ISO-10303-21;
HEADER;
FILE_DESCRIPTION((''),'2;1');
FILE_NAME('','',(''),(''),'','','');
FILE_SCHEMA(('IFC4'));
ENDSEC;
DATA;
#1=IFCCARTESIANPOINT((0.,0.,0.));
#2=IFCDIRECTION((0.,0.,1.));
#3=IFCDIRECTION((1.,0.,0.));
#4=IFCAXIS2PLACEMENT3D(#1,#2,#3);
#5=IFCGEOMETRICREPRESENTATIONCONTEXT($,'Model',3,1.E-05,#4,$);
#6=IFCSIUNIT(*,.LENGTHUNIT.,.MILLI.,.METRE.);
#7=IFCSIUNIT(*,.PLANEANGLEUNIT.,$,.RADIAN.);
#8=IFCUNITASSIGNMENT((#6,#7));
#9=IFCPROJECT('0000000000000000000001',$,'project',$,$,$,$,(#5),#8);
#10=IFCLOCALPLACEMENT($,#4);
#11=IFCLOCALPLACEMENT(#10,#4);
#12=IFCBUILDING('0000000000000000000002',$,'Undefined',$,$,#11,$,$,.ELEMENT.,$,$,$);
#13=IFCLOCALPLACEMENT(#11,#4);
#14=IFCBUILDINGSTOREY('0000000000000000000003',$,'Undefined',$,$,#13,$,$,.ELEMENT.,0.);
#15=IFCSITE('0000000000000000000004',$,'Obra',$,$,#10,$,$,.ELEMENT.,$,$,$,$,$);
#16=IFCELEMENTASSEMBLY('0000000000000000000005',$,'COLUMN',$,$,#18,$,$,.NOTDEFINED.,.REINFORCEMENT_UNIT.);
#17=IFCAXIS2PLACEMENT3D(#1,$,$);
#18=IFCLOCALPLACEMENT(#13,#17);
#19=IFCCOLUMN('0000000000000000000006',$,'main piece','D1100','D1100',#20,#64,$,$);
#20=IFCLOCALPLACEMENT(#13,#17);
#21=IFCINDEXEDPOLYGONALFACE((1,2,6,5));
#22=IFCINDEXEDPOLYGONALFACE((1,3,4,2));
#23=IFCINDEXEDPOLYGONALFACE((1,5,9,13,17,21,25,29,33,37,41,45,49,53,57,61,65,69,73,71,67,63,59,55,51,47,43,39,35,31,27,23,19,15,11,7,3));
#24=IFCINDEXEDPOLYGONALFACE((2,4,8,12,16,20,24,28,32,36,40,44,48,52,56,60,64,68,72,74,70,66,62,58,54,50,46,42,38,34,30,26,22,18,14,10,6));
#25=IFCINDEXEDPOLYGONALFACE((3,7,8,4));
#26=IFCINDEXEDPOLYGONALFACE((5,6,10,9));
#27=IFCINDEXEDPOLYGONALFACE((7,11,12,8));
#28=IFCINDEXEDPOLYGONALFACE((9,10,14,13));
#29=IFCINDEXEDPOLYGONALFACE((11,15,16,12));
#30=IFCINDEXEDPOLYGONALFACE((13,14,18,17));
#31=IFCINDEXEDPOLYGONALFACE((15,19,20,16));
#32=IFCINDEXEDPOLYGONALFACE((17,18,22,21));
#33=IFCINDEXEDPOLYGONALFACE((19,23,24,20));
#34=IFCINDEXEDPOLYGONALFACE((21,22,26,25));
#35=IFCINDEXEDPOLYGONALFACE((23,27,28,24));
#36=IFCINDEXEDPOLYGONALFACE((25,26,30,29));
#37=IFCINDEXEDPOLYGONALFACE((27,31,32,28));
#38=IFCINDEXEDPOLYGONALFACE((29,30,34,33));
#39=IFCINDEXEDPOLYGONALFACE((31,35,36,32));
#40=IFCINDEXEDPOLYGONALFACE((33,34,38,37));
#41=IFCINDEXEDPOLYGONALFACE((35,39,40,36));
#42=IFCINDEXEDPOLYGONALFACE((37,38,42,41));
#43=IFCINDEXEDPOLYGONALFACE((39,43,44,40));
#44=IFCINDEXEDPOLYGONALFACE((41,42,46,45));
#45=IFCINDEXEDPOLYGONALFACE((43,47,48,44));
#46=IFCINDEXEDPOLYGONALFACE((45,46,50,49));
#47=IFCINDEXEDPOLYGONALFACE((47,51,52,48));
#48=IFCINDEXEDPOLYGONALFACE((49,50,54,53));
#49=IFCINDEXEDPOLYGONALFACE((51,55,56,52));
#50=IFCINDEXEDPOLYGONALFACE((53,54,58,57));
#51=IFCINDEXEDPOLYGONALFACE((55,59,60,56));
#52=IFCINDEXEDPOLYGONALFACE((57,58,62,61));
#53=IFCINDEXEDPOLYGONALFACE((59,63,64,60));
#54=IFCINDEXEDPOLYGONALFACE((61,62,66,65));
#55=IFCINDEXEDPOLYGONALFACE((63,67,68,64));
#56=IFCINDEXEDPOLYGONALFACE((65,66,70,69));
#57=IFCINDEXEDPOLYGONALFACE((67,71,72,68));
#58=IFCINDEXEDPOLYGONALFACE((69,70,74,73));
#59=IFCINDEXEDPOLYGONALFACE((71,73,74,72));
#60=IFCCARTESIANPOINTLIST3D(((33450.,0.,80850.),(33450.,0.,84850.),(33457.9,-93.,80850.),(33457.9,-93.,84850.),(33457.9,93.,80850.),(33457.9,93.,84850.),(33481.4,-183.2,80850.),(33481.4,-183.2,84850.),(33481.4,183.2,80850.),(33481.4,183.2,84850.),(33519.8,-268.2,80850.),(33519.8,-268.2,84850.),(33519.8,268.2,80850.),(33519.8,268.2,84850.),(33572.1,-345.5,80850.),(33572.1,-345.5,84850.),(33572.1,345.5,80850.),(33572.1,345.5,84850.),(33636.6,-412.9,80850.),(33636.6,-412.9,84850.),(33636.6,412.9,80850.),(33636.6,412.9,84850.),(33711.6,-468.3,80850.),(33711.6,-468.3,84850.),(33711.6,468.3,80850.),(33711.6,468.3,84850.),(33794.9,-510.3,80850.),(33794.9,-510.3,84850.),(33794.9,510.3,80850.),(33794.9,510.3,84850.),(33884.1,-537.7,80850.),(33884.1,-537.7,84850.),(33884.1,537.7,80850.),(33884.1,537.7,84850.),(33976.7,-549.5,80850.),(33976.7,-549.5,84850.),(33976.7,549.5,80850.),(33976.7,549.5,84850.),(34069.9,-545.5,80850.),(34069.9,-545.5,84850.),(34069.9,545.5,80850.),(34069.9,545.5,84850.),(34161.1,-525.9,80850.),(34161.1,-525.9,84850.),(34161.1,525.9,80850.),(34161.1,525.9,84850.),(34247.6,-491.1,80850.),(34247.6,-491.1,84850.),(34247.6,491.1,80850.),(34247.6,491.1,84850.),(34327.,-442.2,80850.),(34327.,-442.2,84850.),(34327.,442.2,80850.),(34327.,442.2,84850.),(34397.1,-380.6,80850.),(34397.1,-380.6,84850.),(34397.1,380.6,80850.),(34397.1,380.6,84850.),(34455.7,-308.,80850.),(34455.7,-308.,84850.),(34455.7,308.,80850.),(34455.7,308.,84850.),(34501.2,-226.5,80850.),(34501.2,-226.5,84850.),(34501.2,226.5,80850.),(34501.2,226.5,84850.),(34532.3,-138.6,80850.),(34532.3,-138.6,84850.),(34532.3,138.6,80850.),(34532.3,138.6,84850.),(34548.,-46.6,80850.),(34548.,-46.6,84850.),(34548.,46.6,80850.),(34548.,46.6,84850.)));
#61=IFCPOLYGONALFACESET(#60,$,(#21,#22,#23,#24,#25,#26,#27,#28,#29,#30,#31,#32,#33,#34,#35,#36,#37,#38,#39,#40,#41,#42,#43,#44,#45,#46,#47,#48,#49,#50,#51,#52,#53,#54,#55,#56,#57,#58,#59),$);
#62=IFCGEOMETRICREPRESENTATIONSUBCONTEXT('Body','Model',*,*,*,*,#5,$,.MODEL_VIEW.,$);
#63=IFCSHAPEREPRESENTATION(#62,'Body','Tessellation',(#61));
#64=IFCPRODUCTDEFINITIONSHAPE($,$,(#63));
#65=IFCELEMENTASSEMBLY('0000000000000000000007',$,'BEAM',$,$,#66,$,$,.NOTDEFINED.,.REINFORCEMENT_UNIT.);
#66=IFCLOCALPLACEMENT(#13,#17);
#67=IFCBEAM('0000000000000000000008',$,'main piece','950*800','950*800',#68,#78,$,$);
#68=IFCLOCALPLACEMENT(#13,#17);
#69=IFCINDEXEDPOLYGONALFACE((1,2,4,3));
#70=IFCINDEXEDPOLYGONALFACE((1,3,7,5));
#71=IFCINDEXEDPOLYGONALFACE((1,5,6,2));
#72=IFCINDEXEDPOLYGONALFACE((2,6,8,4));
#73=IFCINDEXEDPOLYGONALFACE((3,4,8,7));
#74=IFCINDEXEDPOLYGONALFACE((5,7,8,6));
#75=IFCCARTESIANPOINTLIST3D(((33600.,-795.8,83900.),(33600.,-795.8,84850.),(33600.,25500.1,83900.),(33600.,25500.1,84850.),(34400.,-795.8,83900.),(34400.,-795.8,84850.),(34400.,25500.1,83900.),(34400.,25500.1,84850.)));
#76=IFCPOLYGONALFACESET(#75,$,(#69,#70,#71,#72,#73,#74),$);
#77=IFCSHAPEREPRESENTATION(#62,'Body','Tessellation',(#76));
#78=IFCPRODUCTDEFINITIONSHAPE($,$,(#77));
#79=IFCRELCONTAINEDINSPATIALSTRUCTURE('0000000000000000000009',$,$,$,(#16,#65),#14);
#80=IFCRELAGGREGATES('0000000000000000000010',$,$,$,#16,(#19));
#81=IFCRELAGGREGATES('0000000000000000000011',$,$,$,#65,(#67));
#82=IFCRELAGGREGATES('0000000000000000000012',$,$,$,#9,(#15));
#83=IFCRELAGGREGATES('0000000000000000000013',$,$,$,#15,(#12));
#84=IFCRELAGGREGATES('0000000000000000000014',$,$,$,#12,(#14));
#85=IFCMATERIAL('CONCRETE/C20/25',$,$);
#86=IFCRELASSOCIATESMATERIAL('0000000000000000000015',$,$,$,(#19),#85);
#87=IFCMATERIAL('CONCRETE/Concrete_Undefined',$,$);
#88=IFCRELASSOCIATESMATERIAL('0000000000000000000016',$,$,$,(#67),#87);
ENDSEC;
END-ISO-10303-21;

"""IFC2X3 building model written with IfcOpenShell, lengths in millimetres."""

from ifc_helpers import new_model, si_unit, frame, origin_with_axes, origin_2d_with_axis, place, context, subcontext, project, spatial, rectangle, circle, extrude, material, element, aggregate, save


model = new_model("IFC2X3")

# Units and contexts
model_context = context("Model", 3, precision=1e-05, world=origin_with_axes())
body_context = subcontext(model_context, "Body", "Model", "MODEL_VIEW")
ifc_project = project(units=[si_unit("LENGTHUNIT", "METRE", prefix="MILLI"), si_unit("PLANEANGLEUNIT", "RADIAN")], contexts=[model_context])

# Site, building, storey
site_placement = place(None, origin_with_axes())
site = spatial("IfcSite", under=ifc_project, at=site_placement, Name="Obra", CompositionType="ELEMENT")
building_placement = place(site_placement, origin_with_axes())
building = spatial("IfcBuilding", under=site, at=building_placement, Name="Undefined", CompositionType="ELEMENT")
storey_placement = place(building_placement, origin_with_axes())
storey = spatial("IfcBuildingStorey", under=building, at=storey_placement, Name="Undefined", CompositionType="ELEMENT", Elevation=0.0)

# Element assembly, column
assembly_1_placement = place(storey_placement, origin_with_axes())
assembly_1 = element("IfcElementAssembly", 1, at=assembly_1_placement, inside=storey, Name="COLUMN", AssemblyPlace="NOTDEFINED", PredefinedType="REINFORCEMENT_UNIT")
ifc_material_1 = material(Name="CONCRETE/C20/25")
column_placement = place(assembly_1_placement, frame((34000.0, 0.0, 80850.0), z_axis=(0.0, 0.0, 1.0), x_axis=(0.0, 1.0, 0.0)))
column = element("IfcColumn", 2, at=column_placement, material=ifc_material_1, Name="main piece", Description="D1100", ObjectType="D1100", context=body_context, shape_type="SweptSolid", body=[
    extrude(circle(Radius=550.0, at=origin_2d_with_axis()), frame((0.0, 0.0, 4000.0), z_axis=(0.0, 0.0, -1.0), x_axis=(0.0, 1.0, 0.0)), (0.0, 0.0, 1.0), 4000.0),
])
aggregate(assembly_1, [column])

# Element assembly, beam
assembly_2_placement = place(storey_placement, origin_with_axes())
assembly_2 = element("IfcElementAssembly", 3, at=assembly_2_placement, inside=storey, Name="BEAM", AssemblyPlace="NOTDEFINED", PredefinedType="REINFORCEMENT_UNIT")
ifc_material_2 = material(Name="CONCRETE/Concrete_Undefined")
beam_1_placement = place(assembly_2_placement, frame((34000.0, -795.8, 84375.0), z_axis=(0.0, 0.0, 1.0), x_axis=(0.0, 1.0, 0.0)))
beam_1 = element("IfcBeam", 4, at=beam_1_placement, material=ifc_material_2, Name="main piece", Description="950*800", ObjectType="950*800", context=body_context, shape_type="SweptSolid", body=[
    extrude(rectangle(XDim=800.0, YDim=950.0, at=origin_2d_with_axis()), frame((26296.0, 0.0, 0.0), z_axis=(-1.0, 0.0, 0.0), x_axis=(0.0, -1.0, 0.0)), (0.0, 0.0, 1.0), 26296.0),
])
aggregate(assembly_2, [beam_1])

save(model, "model.ifc")
